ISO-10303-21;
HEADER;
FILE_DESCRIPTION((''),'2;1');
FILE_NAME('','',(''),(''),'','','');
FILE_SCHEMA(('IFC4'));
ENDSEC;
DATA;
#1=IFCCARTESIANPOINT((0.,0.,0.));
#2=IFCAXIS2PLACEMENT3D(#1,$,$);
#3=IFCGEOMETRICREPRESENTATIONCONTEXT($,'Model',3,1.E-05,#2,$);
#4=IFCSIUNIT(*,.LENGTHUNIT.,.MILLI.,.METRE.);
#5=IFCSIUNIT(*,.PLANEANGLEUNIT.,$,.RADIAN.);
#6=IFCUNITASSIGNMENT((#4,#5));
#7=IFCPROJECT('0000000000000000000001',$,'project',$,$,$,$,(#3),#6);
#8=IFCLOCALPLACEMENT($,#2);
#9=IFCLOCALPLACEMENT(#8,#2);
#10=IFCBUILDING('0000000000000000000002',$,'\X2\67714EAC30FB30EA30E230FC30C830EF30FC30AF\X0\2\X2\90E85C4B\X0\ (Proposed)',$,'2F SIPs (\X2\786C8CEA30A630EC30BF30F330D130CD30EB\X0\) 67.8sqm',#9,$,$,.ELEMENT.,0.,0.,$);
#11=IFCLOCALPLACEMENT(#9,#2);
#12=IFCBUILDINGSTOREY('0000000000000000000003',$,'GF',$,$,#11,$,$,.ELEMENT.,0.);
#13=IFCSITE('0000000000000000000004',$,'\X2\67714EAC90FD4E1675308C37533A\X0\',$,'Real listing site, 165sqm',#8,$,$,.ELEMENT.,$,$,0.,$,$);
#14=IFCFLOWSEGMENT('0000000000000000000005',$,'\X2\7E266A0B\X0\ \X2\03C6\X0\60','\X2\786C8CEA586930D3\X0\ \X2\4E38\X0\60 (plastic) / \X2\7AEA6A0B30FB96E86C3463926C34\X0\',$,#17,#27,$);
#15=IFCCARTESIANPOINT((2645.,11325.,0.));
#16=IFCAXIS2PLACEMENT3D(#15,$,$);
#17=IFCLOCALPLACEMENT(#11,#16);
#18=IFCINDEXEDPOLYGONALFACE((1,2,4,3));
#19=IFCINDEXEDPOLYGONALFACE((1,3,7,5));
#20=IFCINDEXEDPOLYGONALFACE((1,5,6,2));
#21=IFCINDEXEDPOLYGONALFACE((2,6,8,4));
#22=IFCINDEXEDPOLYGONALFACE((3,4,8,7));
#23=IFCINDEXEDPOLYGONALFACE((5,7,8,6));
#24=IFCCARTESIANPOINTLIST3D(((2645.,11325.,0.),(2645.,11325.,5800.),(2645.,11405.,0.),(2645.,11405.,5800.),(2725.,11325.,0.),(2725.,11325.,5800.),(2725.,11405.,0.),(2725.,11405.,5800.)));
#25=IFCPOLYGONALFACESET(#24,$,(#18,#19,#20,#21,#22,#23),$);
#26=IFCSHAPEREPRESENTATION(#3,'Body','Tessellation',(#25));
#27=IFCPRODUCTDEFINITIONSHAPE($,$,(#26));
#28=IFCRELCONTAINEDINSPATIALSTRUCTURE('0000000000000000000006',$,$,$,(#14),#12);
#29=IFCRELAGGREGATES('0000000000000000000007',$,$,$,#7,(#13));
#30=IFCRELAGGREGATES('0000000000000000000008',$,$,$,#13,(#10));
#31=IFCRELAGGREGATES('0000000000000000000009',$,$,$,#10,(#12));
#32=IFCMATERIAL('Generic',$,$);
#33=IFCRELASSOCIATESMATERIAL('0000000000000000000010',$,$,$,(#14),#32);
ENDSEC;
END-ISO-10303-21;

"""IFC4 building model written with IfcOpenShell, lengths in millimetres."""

from ifc_helpers import new_model, si_unit, frame, frame_2d, origin, place, context, project, spatial, rectangle, extrude, material, element, save


model = new_model("IFC4")

# Units and contexts
model_context = context("Model", 3, precision=1e-05, world=origin())
ifc_project = project(units=[si_unit("LENGTHUNIT", "METRE", prefix="MILLI"), si_unit("PLANEANGLEUNIT", "RADIAN")], contexts=[model_context])

# Site, building, storey
site_placement = place(None, origin())
site = spatial("IfcSite", under=ifc_project, at=site_placement, Name="東京都世田谷区", ObjectType="Real listing site, 165sqm", CompositionType="ELEMENT", RefElevation=0.0)
building_placement = place(site_placement, origin())
building = spatial("IfcBuilding", under=site, at=building_placement, Name="東京・リモートワーク2部屋 (Proposed)", ObjectType="2F SIPs (硬質ウレタンパネル) 67.8sqm", CompositionType="ELEMENT", ElevationOfRefHeight=0.0, ElevationOfTerrain=0.0)
storey_placement = place(building_placement, origin())
storey = spatial("IfcBuildingStorey", under=building, at=storey_placement, Name="GF", CompositionType="ELEMENT", Elevation=0.0)

# Shared definitions
ifc_material_1 = material(Name="Generic")

# Flow segment
flow_segment_placement = place(storey_placement, frame((2645.0, 11325.0, 0.0)))
element("IfcFlowSegment", 1, at=flow_segment_placement, inside=storey, material=ifc_material_1, Name="縦樋 φ60", Description="硬質塩ビ 丸60 (plastic) / 竪樋・雨水排水", context=model_context, shape_type="SweptSolid", body=[
    extrude(rectangle(XDim=80.0, YDim=80.0, at=frame_2d((40.0, 40.0))), frame((2645.0, 11325.0, 0.0)), (0.0, 0.0, 1.0), 5800.0),
])

save(model, "model.ifc")
